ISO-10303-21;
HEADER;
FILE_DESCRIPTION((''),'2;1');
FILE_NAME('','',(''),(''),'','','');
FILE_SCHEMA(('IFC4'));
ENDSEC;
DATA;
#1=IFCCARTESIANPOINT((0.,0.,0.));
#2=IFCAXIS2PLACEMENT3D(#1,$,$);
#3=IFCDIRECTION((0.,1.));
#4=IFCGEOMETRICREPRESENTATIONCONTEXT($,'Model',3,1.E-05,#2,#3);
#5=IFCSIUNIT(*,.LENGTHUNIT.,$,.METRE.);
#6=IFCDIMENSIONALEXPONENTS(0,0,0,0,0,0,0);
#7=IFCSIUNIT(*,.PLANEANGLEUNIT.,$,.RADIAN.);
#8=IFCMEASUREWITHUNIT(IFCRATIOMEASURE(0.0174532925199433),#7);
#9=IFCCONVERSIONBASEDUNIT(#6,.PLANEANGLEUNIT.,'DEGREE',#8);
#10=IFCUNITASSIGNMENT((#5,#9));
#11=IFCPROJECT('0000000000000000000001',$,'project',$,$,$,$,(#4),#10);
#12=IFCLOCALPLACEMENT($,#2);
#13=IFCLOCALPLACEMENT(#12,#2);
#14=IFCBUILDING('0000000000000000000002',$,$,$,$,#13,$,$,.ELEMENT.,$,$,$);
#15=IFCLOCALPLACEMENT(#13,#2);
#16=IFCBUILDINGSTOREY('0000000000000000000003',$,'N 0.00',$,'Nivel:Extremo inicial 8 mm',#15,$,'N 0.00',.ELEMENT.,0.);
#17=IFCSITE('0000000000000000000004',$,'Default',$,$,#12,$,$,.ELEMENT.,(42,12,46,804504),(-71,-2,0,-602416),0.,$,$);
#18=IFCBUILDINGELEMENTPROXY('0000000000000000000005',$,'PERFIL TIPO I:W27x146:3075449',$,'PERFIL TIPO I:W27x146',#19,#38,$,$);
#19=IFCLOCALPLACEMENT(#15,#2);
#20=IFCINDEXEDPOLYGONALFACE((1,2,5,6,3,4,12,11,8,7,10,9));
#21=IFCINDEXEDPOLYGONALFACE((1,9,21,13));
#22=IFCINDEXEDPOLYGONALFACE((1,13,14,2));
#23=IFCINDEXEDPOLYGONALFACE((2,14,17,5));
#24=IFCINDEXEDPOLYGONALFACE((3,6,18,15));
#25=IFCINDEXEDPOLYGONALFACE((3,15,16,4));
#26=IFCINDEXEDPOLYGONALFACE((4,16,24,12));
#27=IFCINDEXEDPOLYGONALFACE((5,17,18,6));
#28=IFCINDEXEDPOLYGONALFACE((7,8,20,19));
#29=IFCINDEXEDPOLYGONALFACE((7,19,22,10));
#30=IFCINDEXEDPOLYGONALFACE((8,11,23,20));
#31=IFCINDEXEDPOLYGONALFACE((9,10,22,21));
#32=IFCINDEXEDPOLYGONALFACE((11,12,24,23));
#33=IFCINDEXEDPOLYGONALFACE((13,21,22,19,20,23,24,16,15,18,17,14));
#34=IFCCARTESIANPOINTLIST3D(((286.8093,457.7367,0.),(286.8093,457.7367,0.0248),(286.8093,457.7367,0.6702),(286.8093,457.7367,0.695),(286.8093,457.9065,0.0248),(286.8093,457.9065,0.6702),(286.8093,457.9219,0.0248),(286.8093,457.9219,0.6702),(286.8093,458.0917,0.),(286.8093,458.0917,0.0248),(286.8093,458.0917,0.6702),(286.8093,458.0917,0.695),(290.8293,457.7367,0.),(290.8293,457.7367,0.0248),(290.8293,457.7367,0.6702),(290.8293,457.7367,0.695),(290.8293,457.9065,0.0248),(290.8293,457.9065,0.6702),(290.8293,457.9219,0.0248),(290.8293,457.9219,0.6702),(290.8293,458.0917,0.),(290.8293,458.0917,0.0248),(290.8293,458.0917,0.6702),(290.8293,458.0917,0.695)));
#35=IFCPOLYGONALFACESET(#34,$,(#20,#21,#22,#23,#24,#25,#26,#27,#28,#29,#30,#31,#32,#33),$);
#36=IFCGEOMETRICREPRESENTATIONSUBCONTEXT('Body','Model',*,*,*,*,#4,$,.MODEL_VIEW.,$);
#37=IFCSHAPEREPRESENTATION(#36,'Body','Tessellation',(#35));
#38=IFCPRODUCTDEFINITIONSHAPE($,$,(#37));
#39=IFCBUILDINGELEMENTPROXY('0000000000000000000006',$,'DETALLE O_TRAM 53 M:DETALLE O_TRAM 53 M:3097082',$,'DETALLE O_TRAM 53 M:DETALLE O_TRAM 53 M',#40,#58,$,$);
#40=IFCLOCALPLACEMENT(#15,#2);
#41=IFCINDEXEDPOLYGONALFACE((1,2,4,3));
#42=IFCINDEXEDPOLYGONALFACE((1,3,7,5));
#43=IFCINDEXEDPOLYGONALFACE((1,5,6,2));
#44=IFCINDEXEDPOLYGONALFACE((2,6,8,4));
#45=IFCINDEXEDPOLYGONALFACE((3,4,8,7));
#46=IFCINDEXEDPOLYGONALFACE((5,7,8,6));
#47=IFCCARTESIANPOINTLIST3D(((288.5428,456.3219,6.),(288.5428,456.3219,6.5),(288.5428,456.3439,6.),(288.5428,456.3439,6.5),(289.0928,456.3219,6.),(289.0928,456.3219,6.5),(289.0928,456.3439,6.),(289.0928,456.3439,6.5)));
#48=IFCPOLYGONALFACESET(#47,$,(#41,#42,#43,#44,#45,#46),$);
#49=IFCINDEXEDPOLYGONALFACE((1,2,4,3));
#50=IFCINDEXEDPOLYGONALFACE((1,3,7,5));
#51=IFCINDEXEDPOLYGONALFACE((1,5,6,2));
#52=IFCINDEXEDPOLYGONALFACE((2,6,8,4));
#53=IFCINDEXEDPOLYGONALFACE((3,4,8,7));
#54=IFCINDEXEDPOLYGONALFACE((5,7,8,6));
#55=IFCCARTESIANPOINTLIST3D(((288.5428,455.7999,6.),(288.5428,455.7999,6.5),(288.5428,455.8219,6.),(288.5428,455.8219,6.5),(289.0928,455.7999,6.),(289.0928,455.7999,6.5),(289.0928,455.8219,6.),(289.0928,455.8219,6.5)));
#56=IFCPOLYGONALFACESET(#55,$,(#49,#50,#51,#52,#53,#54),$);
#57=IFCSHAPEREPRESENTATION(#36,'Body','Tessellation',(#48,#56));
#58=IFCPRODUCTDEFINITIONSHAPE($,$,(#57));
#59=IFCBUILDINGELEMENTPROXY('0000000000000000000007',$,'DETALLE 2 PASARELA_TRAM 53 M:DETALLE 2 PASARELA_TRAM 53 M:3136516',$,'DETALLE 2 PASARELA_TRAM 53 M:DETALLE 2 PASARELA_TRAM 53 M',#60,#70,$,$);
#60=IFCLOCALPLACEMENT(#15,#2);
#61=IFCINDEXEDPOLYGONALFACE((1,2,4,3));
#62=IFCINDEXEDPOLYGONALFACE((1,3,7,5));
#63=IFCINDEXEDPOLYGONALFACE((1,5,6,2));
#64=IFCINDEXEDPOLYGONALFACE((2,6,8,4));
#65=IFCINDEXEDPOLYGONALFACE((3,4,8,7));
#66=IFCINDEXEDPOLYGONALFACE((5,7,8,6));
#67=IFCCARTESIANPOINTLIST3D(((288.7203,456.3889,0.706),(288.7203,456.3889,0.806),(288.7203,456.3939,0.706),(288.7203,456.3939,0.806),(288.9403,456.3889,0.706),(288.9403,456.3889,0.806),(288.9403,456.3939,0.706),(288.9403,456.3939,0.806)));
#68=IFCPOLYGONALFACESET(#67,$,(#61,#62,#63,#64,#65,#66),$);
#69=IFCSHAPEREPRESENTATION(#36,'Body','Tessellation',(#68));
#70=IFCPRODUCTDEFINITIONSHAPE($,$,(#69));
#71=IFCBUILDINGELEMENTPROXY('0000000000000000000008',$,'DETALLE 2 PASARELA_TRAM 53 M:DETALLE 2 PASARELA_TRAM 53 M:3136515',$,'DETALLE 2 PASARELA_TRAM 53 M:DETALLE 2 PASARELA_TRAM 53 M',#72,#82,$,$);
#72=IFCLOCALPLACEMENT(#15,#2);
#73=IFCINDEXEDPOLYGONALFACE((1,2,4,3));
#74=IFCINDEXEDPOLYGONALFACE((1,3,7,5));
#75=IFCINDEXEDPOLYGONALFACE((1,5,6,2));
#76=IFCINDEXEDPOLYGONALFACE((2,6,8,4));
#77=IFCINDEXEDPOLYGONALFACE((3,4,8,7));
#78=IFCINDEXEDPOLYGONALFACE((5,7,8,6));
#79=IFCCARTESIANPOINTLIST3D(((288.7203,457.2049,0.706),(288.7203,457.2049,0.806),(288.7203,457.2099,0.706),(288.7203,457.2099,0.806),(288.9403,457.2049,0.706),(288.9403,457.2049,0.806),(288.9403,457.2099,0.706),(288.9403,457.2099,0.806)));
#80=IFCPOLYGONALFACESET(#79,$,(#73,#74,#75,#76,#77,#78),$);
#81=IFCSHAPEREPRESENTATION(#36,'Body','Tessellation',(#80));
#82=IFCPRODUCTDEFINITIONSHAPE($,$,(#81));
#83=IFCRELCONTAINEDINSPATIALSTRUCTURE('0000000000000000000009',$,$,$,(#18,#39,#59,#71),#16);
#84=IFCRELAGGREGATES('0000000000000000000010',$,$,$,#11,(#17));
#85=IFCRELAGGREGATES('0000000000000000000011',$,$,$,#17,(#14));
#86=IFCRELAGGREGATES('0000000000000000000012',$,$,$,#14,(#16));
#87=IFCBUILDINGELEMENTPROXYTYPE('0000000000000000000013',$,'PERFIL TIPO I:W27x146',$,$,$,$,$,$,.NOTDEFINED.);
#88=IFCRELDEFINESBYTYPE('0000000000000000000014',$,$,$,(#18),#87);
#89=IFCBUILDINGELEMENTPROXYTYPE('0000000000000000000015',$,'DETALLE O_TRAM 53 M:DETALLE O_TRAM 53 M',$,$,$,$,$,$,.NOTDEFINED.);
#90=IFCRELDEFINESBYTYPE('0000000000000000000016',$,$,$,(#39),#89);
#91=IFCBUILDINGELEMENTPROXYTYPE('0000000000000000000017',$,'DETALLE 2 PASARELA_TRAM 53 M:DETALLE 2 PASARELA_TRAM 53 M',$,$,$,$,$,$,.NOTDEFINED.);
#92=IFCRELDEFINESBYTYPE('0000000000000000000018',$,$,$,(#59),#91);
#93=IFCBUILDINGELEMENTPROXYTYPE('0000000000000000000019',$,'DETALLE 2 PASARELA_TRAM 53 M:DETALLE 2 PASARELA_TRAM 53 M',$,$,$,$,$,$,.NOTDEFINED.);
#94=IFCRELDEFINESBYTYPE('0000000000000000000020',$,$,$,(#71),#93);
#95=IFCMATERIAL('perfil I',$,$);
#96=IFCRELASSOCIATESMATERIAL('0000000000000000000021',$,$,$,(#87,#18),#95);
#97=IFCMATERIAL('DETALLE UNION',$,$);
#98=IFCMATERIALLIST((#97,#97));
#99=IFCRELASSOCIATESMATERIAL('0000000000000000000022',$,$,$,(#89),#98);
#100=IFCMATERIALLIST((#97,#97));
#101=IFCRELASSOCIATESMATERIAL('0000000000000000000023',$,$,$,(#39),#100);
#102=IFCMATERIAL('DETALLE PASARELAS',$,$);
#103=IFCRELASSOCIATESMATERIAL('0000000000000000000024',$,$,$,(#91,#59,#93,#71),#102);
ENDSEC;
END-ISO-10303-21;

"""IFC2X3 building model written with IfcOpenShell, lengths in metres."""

from ifc_helpers import new_model, entity, si_unit, converted_unit, direction, frame, frame_2d, origin, place, context, subcontext, project, spatial, polyline, rectangle, outline, extrude, source, transform, mapped, material, material_list, type_object, type_shapes, element, save


model = new_model("IFC2X3")

# Units and contexts
model_context = context("Model", 3, precision=1e-05, world=origin(), true_north=direction((0.0, 1.0)))
body_context = subcontext(model_context, "Body", "Model", "MODEL_VIEW")
ifc_project = project(units=[si_unit("LENGTHUNIT", "METRE"), converted_unit("PLANEANGLEUNIT", "DEGREE", entity("IfcRatioMeasure", 0.0174532925199433), si_unit("PLANEANGLEUNIT", "RADIAN"), dimensions=[0, 0, 0, 0, 0, 0, 0])], contexts=[model_context])

# Site, building, storey
site_placement = place(None, origin())
site = spatial("IfcSite", under=ifc_project, at=site_placement, Name="Default", CompositionType="ELEMENT", RefLatitude=(42, 12, 46, 804504), RefLongitude=(-71, -2, 0, -602416), RefElevation=0.0)
building_placement = place(site_placement, origin())
building = spatial("IfcBuilding", under=site, at=building_placement, CompositionType="ELEMENT")
storey_placement = place(building_placement, origin())
storey = spatial("IfcBuildingStorey", under=building, at=storey_placement, Name="N 0.00", ObjectType="Nivel:Extremo inicial 8 mm", LongName="N 0.00", CompositionType="ELEMENT", Elevation=0.0)

# Building element proxies
ifc_material_1 = material(Name="perfil I")
building_element_proxy_type_1 = type_object("IfcBuildingElementProxyType", Name="PERFIL TIPO I:W27x146", PredefinedType="NOTDEFINED", material=ifc_material_1)
shared_shape_1 = source(origin(), body_context, "Body", "SweptSolid", [
    extrude(outline(polyline([(0.3227, -0.1775), (0.3475, -0.1775), (0.3475, 0.1775), (0.3227, 0.1775), (0.3227, 0.0077), (-0.3227, 0.0077), (-0.3227, 0.1775), (-0.3475, 0.1775), (-0.3475, -0.1775), (-0.3227, -0.1775), (-0.3227, -0.0077), (0.3227, -0.0077), (0.3227, -0.1775)])), frame((0.0, 0.0, 0.3475), z_axis=(1.0, 0.0, 0.0), x_axis=(0.0, 0.0, 1.0)), (0.0, 0.0, 1.0), 4.02),
])
type_shapes(building_element_proxy_type_1, [shared_shape_1])
proxy_1_placement = place(storey_placement, frame((286.8093, 457.9142, 0.0)))
element("IfcBuildingElementProxy", 1, at=proxy_1_placement, inside=storey, type_object=building_element_proxy_type_1, material=ifc_material_1, Name="PERFIL TIPO I:W27x146:3075449", ObjectType="PERFIL TIPO I:W27x146", context=body_context, shape_type="MappedRepresentation", body=[
    mapped(shared_shape_1, transform((0.0, 0.0, 0.0), scale=1.0)),
])
ifc_material_2 = material(Name="DETALLE UNION")
ifc_material_list_1 = material_list([ifc_material_2, ifc_material_2])
ifc_material_list_2 = material_list([ifc_material_2, ifc_material_2])
building_element_proxy_type_2 = type_object("IfcBuildingElementProxyType", Name="DETALLE O_TRAM 53 M:DETALLE O_TRAM 53 M", PredefinedType="NOTDEFINED", material=ifc_material_list_2)
shared_shape_2 = source(origin(), body_context, "Body", "SweptSolid", [
    extrude(rectangle(XDim=0.55, YDim=0.022, at=frame_2d((0.0, 0.0), x_axis=(1.0, 0.0))), frame((0.275, 0.011, 0.0), z_axis=(0.0, 0.0, 1.0), x_axis=(-1.0, 0.0, 0.0)), (0.0, 0.0, 1.0), 0.5),
    extrude(rectangle(XDim=0.55, YDim=0.022, at=frame_2d((0.0, 0.0), x_axis=(1.0, 0.0))), frame((0.275, -0.511, 0.0), z_axis=(0.0, 0.0, 1.0), x_axis=(-1.0, 0.0, 0.0)), (0.0, 0.0, 1.0), 0.5),
])
type_shapes(building_element_proxy_type_2, [shared_shape_2])
proxy_2_placement = place(storey_placement, frame((288.5428, 456.3219, 6.0)))
element("IfcBuildingElementProxy", 2, at=proxy_2_placement, inside=storey, type_object=building_element_proxy_type_2, material=ifc_material_list_1, Name="DETALLE O_TRAM 53 M:DETALLE O_TRAM 53 M:3097082", ObjectType="DETALLE O_TRAM 53 M:DETALLE O_TRAM 53 M", context=body_context, shape_type="MappedRepresentation", body=[
    mapped(shared_shape_2, transform((0.0, 0.0, 0.0), scale=1.0)),
])
ifc_material_3 = material(Name="DETALLE PASARELAS")
building_element_proxy_type_3 = type_object("IfcBuildingElementProxyType", Name="DETALLE 2 PASARELA_TRAM 53 M:DETALLE 2 PASARELA_TRAM 53 M", PredefinedType="NOTDEFINED", material=ifc_material_3)
shared_shape_3 = source(origin(), body_context, "Body", "SweptSolid", [
    extrude(rectangle(XDim=0.22, YDim=0.005, at=frame_2d((0.0, 0.0), x_axis=(1.0, 0.0))), frame((0.11, 0.0475, 0.0), z_axis=(0.0, 0.0, 1.0), x_axis=(-1.0, 0.0, 0.0)), (0.0, 0.0, 1.0), 0.1),
])
type_shapes(building_element_proxy_type_3, [shared_shape_3])
proxy_3_placement = place(storey_placement, frame((288.7203, 456.3439, 0.706)))
element("IfcBuildingElementProxy", 3, at=proxy_3_placement, inside=storey, type_object=building_element_proxy_type_3, material=ifc_material_3, Name="DETALLE 2 PASARELA_TRAM 53 M:DETALLE 2 PASARELA_TRAM 53 M:3136516", ObjectType="DETALLE 2 PASARELA_TRAM 53 M:DETALLE 2 PASARELA_TRAM 53 M", context=body_context, shape_type="MappedRepresentation", body=[
    mapped(shared_shape_3, transform((0.0, 0.0, 0.0), scale=1.0)),
])
building_element_proxy_type_4 = type_object("IfcBuildingElementProxyType", Name="DETALLE 2 PASARELA_TRAM 53 M:DETALLE 2 PASARELA_TRAM 53 M", PredefinedType="NOTDEFINED", material=ifc_material_3)
shared_shape_4 = source(origin(), body_context, "Body", "SweptSolid", [
    extrude(rectangle(XDim=0.005, YDim=0.22, at=frame_2d((0.0, 0.0), x_axis=(1.0, 0.0))), frame((0.11, -0.0475, 0.0), z_axis=(0.0, 0.0, 1.0), x_axis=(0.0, 1.0, 0.0)), (0.0, 0.0, 1.0), 0.1),
])
type_shapes(building_element_proxy_type_4, [shared_shape_4])
proxy_4_placement = place(storey_placement, frame((288.7203, 457.2549, 0.706)))
element("IfcBuildingElementProxy", 4, at=proxy_4_placement, inside=storey, type_object=building_element_proxy_type_4, material=ifc_material_3, Name="DETALLE 2 PASARELA_TRAM 53 M:DETALLE 2 PASARELA_TRAM 53 M:3136515", ObjectType="DETALLE 2 PASARELA_TRAM 53 M:DETALLE 2 PASARELA_TRAM 53 M", context=body_context, shape_type="MappedRepresentation", body=[
    mapped(shared_shape_4, transform((0.0, 0.0, 0.0), scale=1.0)),
])

save(model, "model.ifc")
